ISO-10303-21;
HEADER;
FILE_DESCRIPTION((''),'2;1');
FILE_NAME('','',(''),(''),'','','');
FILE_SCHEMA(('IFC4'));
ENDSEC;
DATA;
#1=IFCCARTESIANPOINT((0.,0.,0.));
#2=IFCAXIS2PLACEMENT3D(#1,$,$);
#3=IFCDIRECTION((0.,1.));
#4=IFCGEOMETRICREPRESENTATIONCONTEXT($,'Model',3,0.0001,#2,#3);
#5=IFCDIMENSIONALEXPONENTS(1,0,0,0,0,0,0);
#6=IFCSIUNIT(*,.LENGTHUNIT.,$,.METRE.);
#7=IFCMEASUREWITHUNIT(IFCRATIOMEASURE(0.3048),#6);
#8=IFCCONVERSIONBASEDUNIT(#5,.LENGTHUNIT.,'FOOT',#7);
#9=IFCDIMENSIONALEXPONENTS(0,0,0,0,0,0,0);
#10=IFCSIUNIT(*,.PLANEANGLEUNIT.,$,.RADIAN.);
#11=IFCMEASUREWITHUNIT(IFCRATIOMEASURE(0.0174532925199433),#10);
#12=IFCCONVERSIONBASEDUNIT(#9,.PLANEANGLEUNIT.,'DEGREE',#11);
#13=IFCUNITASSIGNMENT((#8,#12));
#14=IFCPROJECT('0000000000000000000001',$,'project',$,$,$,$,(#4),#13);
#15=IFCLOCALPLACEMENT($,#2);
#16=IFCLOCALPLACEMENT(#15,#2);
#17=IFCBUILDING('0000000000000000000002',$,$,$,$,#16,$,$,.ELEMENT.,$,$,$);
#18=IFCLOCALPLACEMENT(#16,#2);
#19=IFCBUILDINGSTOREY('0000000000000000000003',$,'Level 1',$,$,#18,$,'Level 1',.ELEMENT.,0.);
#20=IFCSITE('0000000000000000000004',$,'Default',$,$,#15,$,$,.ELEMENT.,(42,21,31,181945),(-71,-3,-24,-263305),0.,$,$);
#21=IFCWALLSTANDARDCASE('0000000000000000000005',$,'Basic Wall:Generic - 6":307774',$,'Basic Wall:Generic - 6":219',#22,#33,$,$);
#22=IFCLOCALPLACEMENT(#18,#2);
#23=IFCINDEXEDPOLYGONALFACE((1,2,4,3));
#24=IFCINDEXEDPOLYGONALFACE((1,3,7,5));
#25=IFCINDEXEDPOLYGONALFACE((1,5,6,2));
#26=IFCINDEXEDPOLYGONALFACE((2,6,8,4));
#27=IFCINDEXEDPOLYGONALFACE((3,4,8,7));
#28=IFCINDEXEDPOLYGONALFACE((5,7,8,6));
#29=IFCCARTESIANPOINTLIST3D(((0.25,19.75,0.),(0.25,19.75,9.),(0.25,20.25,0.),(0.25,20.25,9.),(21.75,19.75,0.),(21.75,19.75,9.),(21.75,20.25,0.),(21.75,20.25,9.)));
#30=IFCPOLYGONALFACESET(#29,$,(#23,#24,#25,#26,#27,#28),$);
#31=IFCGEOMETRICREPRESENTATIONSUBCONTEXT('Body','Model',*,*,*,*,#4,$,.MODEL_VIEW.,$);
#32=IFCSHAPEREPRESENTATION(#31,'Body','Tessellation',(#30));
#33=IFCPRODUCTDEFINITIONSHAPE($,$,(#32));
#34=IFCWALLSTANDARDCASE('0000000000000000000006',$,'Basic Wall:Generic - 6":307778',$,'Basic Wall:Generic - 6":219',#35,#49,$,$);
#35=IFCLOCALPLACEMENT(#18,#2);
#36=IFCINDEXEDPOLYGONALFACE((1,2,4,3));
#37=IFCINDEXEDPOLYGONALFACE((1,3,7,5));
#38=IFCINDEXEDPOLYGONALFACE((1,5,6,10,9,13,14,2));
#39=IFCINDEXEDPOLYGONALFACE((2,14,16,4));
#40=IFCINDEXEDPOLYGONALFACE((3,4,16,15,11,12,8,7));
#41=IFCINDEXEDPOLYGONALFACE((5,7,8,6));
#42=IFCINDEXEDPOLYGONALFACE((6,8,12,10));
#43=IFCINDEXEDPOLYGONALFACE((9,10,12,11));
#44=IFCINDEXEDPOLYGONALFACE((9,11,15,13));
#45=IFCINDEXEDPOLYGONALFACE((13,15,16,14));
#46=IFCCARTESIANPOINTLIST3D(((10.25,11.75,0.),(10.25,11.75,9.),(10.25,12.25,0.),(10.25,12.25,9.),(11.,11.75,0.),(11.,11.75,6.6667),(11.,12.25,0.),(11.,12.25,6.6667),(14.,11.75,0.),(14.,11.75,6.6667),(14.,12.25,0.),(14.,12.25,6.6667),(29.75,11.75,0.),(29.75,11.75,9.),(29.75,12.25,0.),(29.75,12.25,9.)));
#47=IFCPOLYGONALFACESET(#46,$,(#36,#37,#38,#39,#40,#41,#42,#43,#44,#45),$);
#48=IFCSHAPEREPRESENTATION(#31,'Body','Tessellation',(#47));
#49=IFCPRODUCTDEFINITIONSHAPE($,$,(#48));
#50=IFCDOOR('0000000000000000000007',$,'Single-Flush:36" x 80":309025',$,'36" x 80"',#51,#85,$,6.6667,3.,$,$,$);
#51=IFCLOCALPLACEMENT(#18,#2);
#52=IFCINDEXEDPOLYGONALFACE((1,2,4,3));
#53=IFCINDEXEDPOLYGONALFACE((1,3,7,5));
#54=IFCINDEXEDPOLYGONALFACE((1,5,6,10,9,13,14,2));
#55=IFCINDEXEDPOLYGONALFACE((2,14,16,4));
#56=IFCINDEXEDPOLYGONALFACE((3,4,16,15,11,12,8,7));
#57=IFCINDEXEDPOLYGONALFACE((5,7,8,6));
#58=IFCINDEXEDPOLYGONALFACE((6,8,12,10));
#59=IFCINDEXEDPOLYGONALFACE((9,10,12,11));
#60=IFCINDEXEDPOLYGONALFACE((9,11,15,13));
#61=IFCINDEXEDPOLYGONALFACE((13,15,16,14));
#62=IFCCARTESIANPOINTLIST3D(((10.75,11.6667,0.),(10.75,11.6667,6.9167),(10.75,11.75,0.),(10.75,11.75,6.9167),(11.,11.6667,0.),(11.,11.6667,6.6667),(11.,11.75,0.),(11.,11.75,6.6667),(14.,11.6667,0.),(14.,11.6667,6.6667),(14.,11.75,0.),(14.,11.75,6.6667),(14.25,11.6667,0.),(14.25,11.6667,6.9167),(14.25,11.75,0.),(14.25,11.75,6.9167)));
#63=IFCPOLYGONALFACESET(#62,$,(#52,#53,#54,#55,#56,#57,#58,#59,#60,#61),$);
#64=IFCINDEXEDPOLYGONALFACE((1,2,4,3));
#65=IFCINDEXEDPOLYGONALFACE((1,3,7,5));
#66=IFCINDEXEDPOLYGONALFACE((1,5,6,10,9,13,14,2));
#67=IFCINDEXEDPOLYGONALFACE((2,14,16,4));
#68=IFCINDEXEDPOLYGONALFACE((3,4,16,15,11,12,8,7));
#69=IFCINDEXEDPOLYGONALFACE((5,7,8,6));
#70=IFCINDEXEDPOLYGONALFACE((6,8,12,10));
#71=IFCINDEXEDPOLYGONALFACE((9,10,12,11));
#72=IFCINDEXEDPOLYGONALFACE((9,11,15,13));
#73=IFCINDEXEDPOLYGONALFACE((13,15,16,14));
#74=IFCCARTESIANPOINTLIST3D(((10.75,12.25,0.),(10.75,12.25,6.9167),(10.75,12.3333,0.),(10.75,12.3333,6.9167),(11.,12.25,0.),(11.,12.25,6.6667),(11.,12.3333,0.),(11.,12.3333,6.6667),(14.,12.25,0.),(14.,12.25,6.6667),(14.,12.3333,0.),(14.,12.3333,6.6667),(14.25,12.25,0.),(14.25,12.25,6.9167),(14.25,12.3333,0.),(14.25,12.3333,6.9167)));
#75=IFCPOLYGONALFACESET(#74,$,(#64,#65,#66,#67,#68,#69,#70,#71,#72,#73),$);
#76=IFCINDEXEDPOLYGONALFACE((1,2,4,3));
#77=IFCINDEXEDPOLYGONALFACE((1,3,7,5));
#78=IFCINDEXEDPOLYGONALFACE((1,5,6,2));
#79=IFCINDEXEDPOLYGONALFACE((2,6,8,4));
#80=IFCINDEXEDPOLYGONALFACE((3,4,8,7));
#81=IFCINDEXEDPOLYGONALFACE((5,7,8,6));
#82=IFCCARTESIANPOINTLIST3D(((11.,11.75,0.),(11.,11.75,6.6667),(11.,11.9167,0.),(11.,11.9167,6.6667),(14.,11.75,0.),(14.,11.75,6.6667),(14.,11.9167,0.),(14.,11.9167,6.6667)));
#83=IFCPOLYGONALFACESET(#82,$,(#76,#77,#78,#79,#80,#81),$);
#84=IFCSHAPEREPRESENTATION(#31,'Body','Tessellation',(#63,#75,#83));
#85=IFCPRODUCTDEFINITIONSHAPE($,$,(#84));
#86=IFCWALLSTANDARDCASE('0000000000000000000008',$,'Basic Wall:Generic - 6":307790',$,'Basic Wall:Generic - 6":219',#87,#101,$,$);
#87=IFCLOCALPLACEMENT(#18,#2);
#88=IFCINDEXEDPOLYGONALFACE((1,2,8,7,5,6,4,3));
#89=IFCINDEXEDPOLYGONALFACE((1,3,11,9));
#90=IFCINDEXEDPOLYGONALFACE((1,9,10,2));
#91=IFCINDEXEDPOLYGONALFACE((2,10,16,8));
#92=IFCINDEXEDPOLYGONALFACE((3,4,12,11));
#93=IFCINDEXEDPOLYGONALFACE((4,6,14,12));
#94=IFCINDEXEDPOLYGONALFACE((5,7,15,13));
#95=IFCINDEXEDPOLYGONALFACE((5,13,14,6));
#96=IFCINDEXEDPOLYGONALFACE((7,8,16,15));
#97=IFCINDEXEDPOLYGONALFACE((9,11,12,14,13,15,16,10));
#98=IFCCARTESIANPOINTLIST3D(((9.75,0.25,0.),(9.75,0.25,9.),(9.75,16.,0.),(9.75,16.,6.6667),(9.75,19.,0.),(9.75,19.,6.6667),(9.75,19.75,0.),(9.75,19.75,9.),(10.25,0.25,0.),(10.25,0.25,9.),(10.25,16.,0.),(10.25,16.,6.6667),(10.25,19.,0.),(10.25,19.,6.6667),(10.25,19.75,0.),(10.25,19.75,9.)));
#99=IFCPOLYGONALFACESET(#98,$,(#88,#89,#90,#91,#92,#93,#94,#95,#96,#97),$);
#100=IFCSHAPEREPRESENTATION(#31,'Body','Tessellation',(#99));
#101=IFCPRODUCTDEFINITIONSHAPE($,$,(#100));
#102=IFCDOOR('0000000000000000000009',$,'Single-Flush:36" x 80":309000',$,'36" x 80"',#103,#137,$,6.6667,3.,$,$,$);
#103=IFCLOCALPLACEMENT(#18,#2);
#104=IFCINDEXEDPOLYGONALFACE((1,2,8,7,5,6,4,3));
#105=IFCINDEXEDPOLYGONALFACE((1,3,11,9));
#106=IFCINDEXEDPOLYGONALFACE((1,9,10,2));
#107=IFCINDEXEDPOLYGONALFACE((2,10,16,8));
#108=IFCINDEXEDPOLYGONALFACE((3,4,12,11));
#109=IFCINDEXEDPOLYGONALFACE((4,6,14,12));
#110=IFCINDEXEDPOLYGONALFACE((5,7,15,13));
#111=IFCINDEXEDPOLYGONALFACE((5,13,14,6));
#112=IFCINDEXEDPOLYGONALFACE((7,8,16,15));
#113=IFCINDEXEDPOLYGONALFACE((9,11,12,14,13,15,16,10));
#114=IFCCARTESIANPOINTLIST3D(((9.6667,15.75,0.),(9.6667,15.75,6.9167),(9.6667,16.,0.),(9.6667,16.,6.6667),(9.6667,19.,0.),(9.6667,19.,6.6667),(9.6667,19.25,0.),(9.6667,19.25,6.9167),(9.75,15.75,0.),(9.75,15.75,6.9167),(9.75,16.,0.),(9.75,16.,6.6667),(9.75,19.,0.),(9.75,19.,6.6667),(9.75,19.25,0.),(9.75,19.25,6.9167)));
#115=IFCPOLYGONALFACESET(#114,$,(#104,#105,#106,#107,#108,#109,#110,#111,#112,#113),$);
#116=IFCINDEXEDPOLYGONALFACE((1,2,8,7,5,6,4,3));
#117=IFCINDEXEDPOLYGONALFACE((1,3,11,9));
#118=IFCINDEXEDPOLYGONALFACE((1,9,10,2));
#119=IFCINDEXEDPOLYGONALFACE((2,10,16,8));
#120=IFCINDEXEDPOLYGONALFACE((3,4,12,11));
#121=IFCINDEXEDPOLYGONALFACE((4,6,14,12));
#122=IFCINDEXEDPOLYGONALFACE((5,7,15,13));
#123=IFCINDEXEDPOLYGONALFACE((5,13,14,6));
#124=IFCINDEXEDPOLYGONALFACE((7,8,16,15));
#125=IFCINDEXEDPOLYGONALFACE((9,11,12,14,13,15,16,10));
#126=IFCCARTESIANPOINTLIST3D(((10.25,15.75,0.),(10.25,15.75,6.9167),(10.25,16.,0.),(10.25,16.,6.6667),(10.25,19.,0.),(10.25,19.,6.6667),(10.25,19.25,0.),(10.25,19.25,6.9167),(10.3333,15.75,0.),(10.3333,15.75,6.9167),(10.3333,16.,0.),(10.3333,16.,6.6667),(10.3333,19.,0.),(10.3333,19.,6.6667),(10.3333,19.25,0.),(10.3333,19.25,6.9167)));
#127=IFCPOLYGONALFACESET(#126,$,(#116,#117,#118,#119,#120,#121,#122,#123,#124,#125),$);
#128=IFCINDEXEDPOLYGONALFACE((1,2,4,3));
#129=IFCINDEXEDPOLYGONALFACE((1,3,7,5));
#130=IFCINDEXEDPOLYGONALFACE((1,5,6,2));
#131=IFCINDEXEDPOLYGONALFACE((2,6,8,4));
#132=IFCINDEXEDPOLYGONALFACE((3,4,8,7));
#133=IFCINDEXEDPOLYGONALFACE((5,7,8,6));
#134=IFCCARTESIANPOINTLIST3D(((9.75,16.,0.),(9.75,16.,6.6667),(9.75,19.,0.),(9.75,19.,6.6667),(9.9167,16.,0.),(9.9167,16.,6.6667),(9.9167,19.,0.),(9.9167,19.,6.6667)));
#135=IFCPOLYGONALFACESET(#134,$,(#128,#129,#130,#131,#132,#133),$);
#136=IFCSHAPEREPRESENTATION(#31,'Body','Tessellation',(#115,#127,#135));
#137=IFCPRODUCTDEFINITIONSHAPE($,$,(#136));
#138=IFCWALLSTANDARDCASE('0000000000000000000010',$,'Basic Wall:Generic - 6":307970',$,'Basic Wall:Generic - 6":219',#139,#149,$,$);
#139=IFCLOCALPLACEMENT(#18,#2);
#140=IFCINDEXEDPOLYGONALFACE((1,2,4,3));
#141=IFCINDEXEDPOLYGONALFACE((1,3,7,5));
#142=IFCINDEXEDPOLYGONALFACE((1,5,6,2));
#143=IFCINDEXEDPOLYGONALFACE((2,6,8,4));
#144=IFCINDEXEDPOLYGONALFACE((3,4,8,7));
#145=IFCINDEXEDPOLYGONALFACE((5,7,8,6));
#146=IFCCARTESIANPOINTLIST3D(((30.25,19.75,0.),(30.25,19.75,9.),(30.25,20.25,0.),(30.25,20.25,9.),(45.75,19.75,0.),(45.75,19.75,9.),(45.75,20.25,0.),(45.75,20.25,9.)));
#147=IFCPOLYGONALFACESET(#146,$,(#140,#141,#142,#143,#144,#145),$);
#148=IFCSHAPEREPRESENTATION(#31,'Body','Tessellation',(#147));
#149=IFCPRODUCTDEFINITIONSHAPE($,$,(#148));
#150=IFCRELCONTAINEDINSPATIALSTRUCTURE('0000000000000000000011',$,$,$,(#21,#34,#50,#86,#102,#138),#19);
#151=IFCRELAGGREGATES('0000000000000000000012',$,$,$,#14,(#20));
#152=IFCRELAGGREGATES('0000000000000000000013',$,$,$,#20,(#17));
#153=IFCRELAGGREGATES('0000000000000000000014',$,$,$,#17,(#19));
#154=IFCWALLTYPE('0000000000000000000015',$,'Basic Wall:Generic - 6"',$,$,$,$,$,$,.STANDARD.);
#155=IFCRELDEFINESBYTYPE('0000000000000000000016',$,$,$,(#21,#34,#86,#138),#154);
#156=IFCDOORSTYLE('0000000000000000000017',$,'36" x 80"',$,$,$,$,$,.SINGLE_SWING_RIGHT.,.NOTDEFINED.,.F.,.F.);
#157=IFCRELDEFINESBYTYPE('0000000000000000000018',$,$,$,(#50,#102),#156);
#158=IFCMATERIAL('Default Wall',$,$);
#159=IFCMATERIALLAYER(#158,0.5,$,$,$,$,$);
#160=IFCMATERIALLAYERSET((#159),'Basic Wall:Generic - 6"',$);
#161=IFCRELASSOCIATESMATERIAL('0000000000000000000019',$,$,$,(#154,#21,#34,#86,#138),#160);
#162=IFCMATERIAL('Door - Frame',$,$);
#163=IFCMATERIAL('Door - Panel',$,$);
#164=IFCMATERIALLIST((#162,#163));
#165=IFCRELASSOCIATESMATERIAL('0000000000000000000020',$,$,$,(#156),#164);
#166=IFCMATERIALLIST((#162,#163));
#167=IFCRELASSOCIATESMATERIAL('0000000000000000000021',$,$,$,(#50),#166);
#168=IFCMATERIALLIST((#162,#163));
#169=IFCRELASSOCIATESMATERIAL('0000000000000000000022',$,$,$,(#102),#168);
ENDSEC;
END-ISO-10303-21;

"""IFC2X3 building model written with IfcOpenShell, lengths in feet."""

from ifc_helpers import new_model, entity, si_unit, converted_unit, direction, frame, frame_2d, origin, origin_2d_with_axis, place, context, subcontext, project, spatial, polyline, rectangle, outline, extrude, clip, bounded_halfspace, source, transform, mapped, material, material_list, layer, layer_set, layer_usage, type_object, type_shapes, element, fill, save


model = new_model("IFC2X3")

# Units and contexts
model_context = context("Model", 3, precision=0.0001, world=origin(), true_north=direction((0.0, 1.0)))
body_context = subcontext(model_context, "Body", "Model", "MODEL_VIEW")
ifc_project = project(units=[converted_unit("LENGTHUNIT", "FOOT", entity("IfcRatioMeasure", 0.3048), si_unit("LENGTHUNIT", "METRE"), dimensions=[1, 0, 0, 0, 0, 0, 0]), converted_unit("PLANEANGLEUNIT", "DEGREE", entity("IfcRatioMeasure", 0.0174532925199433), si_unit("PLANEANGLEUNIT", "RADIAN"), dimensions=[0, 0, 0, 0, 0, 0, 0])], contexts=[model_context])

# Site, building, storey
site_placement = place(None, origin())
site = spatial("IfcSite", under=ifc_project, at=site_placement, Name="Default", CompositionType="ELEMENT", RefLatitude=(42, 21, 31, 181945), RefLongitude=(-71, -3, -24, -263305), RefElevation=0.0)
building_placement = place(site_placement, origin())
building = spatial("IfcBuilding", under=site, at=building_placement, CompositionType="ELEMENT")
storey_placement = place(building_placement, origin())
storey = spatial("IfcBuildingStorey", under=building, at=storey_placement, Name="Level 1", LongName="Level 1", CompositionType="ELEMENT", Elevation=0.0)

# Shared definitions
ifc_material_1 = material(Name="Default Wall")
ifc_layer = layer(ifc_material_1, 0.5)
ifc_layer_set = layer_set([ifc_layer], Name="Basic Wall:Generic - 6\"")
wall_type = type_object("IfcWallType", Name="Basic Wall:Generic - 6\"", PredefinedType="STANDARD", material=ifc_layer_set)

# Wall
ifc_layer_usage_1 = layer_usage(ifc_layer_set, "AXIS2", "NEGATIVE", 0.25)
wall_1_placement = place(storey_placement, frame((0.25, 20.0, 0.0)))
element("IfcWallStandardCase", 1, at=wall_1_placement, inside=storey, type_object=wall_type, material=ifc_layer_usage_1, Name="Basic Wall:Generic - 6\":307774", ObjectType="Basic Wall:Generic - 6\":219", context=body_context, shape_type="Clipping", body=[
    clip(clip(extrude(rectangle(XDim=21.5, YDim=0.5, at=frame_2d((10.75, 0.0), x_axis=(-1.0, 0.0))), origin(), (0.0, 0.0, 1.0), 9.0), bounded_halfspace(frame((21.5, -0.25, 9.0), z_axis=(0.0, 0.0, -1.0), x_axis=(0.0, -1.0, 0.0)), True, frame((21.5, -0.25, 9.0)), polyline([(0.0, 0.0), (0.0, 0.5), (-12.0, 0.5), (-12.0, 0.0), (-11.5, 0.0), (0.0, 0.0)]))), bounded_halfspace(frame((0.0, -0.25, 9.0), z_axis=(0.0, 0.0, -1.0), x_axis=(0.0, -1.0, 0.0)), True, frame((0.0, -0.25, 9.0)), polyline([(0.0, 0.0), (9.5, 0.0), (9.5, 0.5), (0.0, 0.5), (0.0, 0.0)]))),
])

# Walls, openings, doors
ifc_layer_usage_2 = layer_usage(ifc_layer_set, "AXIS2", "NEGATIVE", 0.25)
wall_2_placement = place(storey_placement, frame((10.25, 12.0, 0.0)))
wall_2 = element("IfcWallStandardCase", 2, at=wall_2_placement, inside=storey, type_object=wall_type, material=ifc_layer_usage_2, Name="Basic Wall:Generic - 6\":307778", ObjectType="Basic Wall:Generic - 6\":219", context=body_context, shape_type="Clipping", body=[
    clip(extrude(rectangle(XDim=19.5, YDim=0.5, at=frame_2d((9.75, 0.0), x_axis=(-1.0, 0.0))), origin(), (0.0, 0.0, 1.0), 9.0), bounded_halfspace(frame((0.0, -0.25, 9.0), z_axis=(0.0, 0.0, -1.0), x_axis=(0.0, -1.0, 0.0)), True, frame((0.0, -0.25, 9.0)), polyline([(0.0, 0.0), (19.5, 0.0), (19.5, 0.5), (0.0, 0.5), (0.0, 0.0)]))),
])
opening_1_placement = place(wall_2_placement, frame((3.75, 0.25, 0.0)))
opening_1 = element("IfcOpeningElement", 3, at=opening_1_placement, cuts=wall_2, ObjectType="Opening", context=body_context, shape_type="SweptSolid", body=[
    extrude(rectangle(XDim=3.0, YDim=6.6667, at=frame_2d((3.3333, 1.5), x_axis=(0.0, 1.0))), frame((0.0, 0.0, 0.0), z_axis=(0.0, -1.0, 0.0), x_axis=(0.0, 0.0, 1.0)), (0.0, 0.0, 1.0), 0.5),
])
ifc_material_2 = material(Name="Door - Frame")
ifc_material_3 = material(Name="Door - Panel")
ifc_material_list_1 = material_list([ifc_material_2, ifc_material_3])
ifc_material_list_2 = material_list([ifc_material_2, ifc_material_3])
door_style = type_object("IfcDoorStyle", Name="36\" x 80\"", ConstructionType="NOTDEFINED", OperationType="SINGLE_SWING_RIGHT", ParameterTakesPrecedence=False, Sizeable=False, material=ifc_material_list_2)
shared_shape_1 = source(origin(), body_context, "Body", "SweptSolid", [
    extrude(outline(polyline([(-1.75, -3.5208), (1.75, -3.5208), (1.75, 3.3958), (1.5, 3.3958), (1.5, -3.2708), (-1.5, -3.2708), (-1.5, 3.3958), (-1.75, 3.3958), (-1.75, -3.5208)])), frame((1.5, 0.5, 3.3958), z_axis=(0.0, 1.0, 0.0), x_axis=(1.0, 0.0, 0.0)), (0.0, 0.0, 1.0), 0.0833),
    extrude(outline(polyline([(-3.5208, -1.75), (3.3958, -1.75), (3.3958, -1.5), (-3.2708, -1.5), (-3.2708, 1.5), (3.3958, 1.5), (3.3958, 1.75), (-3.5208, 1.75), (-3.5208, -1.75)])), frame((1.5, -0.0833, 3.3958), z_axis=(0.0, 1.0, 0.0), x_axis=(0.0, 0.0, -1.0)), (0.0, 0.0, 1.0), 0.0833),
    extrude(rectangle(XDim=0.1667, YDim=3.0, at=origin_2d_with_axis()), frame((1.5, 0.4167, 0.0), z_axis=(0.0, 0.0, 1.0), x_axis=(0.0, 1.0, 0.0)), (0.0, 0.0, 1.0), 6.6667),
])
type_shapes(door_style, [shared_shape_1])
door_1_placement = place(opening_1_placement, frame((0.0, 0.0, 0.0), z_axis=(0.0, 0.0, 1.0), x_axis=(-1.0, 0.0, 0.0)))
door_1 = element("IfcDoor", 4, at=door_1_placement, inside=storey, type_object=door_style, material=ifc_material_list_1, Name="Single-Flush:36\" x 80\":309025", ObjectType="36\" x 80\"", OverallHeight=6.6667, OverallWidth=3.0, context=body_context, shape_type="MappedRepresentation", body=[
    mapped(shared_shape_1, transform((0.0, 0.0, 0.0), scale=1.0)),
])
fill(opening_1, door_1)
ifc_layer_usage_3 = layer_usage(ifc_layer_set, "AXIS2", "NEGATIVE", 0.25)
wall_3_placement = place(storey_placement, frame((10.0, 19.75, 0.0), z_axis=(0.0, 0.0, 1.0), x_axis=(0.0, -1.0, 0.0)))
wall_3 = element("IfcWallStandardCase", 5, at=wall_3_placement, inside=storey, type_object=wall_type, material=ifc_layer_usage_3, Name="Basic Wall:Generic - 6\":307790", ObjectType="Basic Wall:Generic - 6\":219", context=body_context, shape_type="Clipping", body=[
    clip(clip(extrude(rectangle(XDim=19.5, YDim=0.5, at=frame_2d((9.75, 0.0), x_axis=(-1.0, 0.0))), origin(), (0.0, 0.0, 1.0), 9.0), bounded_halfspace(frame((8.0, -0.25, 9.0), z_axis=(0.0, 0.0, -1.0), x_axis=(0.0, 1.0, 0.0)), True, frame((8.0, -0.25, 9.0)), polyline([(0.0, 0.0), (11.5, 0.0), (11.5, 0.5), (0.0, 0.5), (0.0, 0.0)]))), bounded_halfspace(frame((8.0, -0.25, 9.0), z_axis=(0.0, 0.0, -1.0), x_axis=(1.0, 0.0, 0.0)), True, frame((8.0, -0.25, 9.0)), polyline([(0.0, 0.0), (0.0, 0.5), (-0.5, 0.5), (-8.0, 0.5), (-8.0, 0.0), (0.0, 0.0)]))),
])
opening_2_placement = place(wall_3_placement, frame((3.75, 0.25, 0.0)))
opening_2 = element("IfcOpeningElement", 6, at=opening_2_placement, cuts=wall_3, ObjectType="Opening", context=body_context, shape_type="SweptSolid", body=[
    extrude(rectangle(XDim=3.0, YDim=6.6667, at=frame_2d((3.3333, 1.5), x_axis=(0.0, 1.0))), frame((0.0, 0.0, 0.0), z_axis=(0.0, -1.0, 0.0), x_axis=(0.0, 0.0, 1.0)), (0.0, 0.0, 1.0), 0.5),
])
ifc_material_list_3 = material_list([ifc_material_2, ifc_material_3])
door_2_placement = place(opening_2_placement, frame((0.0, 0.0, 0.0), z_axis=(0.0, 0.0, 1.0), x_axis=(-1.0, 0.0, 0.0)))
door_2 = element("IfcDoor", 7, at=door_2_placement, inside=storey, type_object=door_style, material=ifc_material_list_3, Name="Single-Flush:36\" x 80\":309000", ObjectType="36\" x 80\"", OverallHeight=6.6667, OverallWidth=3.0, context=body_context, shape_type="MappedRepresentation", body=[
    mapped(shared_shape_1, transform((0.0, 0.0, 0.0), scale=1.0)),
])
fill(opening_2, door_2)

# Wall
ifc_layer_usage_4 = layer_usage(ifc_layer_set, "AXIS2", "NEGATIVE", 0.25)
wall_4_placement = place(storey_placement, frame((30.25, 20.0, 0.0)))
element("IfcWallStandardCase", 8, at=wall_4_placement, inside=storey, type_object=wall_type, material=ifc_layer_usage_4, Name="Basic Wall:Generic - 6\":307970", ObjectType="Basic Wall:Generic - 6\":219", context=body_context, shape_type="Clipping", body=[
    clip(extrude(rectangle(XDim=15.5, YDim=0.5, at=frame_2d((7.75, 0.0), x_axis=(-1.0, 0.0))), origin(), (0.0, 0.0, 1.0), 9.0), bounded_halfspace(frame((0.0, -0.25, 9.0), z_axis=(0.0, 0.0, -1.0), x_axis=(1.0, 0.0, 0.0)), True, frame((0.0, -0.25, 9.0)), polyline([(0.0, 0.0), (15.5, 0.0), (15.5, 0.5), (0.0, 0.5), (0.0, 0.0)]))),
])

save(model, "model.ifc")
